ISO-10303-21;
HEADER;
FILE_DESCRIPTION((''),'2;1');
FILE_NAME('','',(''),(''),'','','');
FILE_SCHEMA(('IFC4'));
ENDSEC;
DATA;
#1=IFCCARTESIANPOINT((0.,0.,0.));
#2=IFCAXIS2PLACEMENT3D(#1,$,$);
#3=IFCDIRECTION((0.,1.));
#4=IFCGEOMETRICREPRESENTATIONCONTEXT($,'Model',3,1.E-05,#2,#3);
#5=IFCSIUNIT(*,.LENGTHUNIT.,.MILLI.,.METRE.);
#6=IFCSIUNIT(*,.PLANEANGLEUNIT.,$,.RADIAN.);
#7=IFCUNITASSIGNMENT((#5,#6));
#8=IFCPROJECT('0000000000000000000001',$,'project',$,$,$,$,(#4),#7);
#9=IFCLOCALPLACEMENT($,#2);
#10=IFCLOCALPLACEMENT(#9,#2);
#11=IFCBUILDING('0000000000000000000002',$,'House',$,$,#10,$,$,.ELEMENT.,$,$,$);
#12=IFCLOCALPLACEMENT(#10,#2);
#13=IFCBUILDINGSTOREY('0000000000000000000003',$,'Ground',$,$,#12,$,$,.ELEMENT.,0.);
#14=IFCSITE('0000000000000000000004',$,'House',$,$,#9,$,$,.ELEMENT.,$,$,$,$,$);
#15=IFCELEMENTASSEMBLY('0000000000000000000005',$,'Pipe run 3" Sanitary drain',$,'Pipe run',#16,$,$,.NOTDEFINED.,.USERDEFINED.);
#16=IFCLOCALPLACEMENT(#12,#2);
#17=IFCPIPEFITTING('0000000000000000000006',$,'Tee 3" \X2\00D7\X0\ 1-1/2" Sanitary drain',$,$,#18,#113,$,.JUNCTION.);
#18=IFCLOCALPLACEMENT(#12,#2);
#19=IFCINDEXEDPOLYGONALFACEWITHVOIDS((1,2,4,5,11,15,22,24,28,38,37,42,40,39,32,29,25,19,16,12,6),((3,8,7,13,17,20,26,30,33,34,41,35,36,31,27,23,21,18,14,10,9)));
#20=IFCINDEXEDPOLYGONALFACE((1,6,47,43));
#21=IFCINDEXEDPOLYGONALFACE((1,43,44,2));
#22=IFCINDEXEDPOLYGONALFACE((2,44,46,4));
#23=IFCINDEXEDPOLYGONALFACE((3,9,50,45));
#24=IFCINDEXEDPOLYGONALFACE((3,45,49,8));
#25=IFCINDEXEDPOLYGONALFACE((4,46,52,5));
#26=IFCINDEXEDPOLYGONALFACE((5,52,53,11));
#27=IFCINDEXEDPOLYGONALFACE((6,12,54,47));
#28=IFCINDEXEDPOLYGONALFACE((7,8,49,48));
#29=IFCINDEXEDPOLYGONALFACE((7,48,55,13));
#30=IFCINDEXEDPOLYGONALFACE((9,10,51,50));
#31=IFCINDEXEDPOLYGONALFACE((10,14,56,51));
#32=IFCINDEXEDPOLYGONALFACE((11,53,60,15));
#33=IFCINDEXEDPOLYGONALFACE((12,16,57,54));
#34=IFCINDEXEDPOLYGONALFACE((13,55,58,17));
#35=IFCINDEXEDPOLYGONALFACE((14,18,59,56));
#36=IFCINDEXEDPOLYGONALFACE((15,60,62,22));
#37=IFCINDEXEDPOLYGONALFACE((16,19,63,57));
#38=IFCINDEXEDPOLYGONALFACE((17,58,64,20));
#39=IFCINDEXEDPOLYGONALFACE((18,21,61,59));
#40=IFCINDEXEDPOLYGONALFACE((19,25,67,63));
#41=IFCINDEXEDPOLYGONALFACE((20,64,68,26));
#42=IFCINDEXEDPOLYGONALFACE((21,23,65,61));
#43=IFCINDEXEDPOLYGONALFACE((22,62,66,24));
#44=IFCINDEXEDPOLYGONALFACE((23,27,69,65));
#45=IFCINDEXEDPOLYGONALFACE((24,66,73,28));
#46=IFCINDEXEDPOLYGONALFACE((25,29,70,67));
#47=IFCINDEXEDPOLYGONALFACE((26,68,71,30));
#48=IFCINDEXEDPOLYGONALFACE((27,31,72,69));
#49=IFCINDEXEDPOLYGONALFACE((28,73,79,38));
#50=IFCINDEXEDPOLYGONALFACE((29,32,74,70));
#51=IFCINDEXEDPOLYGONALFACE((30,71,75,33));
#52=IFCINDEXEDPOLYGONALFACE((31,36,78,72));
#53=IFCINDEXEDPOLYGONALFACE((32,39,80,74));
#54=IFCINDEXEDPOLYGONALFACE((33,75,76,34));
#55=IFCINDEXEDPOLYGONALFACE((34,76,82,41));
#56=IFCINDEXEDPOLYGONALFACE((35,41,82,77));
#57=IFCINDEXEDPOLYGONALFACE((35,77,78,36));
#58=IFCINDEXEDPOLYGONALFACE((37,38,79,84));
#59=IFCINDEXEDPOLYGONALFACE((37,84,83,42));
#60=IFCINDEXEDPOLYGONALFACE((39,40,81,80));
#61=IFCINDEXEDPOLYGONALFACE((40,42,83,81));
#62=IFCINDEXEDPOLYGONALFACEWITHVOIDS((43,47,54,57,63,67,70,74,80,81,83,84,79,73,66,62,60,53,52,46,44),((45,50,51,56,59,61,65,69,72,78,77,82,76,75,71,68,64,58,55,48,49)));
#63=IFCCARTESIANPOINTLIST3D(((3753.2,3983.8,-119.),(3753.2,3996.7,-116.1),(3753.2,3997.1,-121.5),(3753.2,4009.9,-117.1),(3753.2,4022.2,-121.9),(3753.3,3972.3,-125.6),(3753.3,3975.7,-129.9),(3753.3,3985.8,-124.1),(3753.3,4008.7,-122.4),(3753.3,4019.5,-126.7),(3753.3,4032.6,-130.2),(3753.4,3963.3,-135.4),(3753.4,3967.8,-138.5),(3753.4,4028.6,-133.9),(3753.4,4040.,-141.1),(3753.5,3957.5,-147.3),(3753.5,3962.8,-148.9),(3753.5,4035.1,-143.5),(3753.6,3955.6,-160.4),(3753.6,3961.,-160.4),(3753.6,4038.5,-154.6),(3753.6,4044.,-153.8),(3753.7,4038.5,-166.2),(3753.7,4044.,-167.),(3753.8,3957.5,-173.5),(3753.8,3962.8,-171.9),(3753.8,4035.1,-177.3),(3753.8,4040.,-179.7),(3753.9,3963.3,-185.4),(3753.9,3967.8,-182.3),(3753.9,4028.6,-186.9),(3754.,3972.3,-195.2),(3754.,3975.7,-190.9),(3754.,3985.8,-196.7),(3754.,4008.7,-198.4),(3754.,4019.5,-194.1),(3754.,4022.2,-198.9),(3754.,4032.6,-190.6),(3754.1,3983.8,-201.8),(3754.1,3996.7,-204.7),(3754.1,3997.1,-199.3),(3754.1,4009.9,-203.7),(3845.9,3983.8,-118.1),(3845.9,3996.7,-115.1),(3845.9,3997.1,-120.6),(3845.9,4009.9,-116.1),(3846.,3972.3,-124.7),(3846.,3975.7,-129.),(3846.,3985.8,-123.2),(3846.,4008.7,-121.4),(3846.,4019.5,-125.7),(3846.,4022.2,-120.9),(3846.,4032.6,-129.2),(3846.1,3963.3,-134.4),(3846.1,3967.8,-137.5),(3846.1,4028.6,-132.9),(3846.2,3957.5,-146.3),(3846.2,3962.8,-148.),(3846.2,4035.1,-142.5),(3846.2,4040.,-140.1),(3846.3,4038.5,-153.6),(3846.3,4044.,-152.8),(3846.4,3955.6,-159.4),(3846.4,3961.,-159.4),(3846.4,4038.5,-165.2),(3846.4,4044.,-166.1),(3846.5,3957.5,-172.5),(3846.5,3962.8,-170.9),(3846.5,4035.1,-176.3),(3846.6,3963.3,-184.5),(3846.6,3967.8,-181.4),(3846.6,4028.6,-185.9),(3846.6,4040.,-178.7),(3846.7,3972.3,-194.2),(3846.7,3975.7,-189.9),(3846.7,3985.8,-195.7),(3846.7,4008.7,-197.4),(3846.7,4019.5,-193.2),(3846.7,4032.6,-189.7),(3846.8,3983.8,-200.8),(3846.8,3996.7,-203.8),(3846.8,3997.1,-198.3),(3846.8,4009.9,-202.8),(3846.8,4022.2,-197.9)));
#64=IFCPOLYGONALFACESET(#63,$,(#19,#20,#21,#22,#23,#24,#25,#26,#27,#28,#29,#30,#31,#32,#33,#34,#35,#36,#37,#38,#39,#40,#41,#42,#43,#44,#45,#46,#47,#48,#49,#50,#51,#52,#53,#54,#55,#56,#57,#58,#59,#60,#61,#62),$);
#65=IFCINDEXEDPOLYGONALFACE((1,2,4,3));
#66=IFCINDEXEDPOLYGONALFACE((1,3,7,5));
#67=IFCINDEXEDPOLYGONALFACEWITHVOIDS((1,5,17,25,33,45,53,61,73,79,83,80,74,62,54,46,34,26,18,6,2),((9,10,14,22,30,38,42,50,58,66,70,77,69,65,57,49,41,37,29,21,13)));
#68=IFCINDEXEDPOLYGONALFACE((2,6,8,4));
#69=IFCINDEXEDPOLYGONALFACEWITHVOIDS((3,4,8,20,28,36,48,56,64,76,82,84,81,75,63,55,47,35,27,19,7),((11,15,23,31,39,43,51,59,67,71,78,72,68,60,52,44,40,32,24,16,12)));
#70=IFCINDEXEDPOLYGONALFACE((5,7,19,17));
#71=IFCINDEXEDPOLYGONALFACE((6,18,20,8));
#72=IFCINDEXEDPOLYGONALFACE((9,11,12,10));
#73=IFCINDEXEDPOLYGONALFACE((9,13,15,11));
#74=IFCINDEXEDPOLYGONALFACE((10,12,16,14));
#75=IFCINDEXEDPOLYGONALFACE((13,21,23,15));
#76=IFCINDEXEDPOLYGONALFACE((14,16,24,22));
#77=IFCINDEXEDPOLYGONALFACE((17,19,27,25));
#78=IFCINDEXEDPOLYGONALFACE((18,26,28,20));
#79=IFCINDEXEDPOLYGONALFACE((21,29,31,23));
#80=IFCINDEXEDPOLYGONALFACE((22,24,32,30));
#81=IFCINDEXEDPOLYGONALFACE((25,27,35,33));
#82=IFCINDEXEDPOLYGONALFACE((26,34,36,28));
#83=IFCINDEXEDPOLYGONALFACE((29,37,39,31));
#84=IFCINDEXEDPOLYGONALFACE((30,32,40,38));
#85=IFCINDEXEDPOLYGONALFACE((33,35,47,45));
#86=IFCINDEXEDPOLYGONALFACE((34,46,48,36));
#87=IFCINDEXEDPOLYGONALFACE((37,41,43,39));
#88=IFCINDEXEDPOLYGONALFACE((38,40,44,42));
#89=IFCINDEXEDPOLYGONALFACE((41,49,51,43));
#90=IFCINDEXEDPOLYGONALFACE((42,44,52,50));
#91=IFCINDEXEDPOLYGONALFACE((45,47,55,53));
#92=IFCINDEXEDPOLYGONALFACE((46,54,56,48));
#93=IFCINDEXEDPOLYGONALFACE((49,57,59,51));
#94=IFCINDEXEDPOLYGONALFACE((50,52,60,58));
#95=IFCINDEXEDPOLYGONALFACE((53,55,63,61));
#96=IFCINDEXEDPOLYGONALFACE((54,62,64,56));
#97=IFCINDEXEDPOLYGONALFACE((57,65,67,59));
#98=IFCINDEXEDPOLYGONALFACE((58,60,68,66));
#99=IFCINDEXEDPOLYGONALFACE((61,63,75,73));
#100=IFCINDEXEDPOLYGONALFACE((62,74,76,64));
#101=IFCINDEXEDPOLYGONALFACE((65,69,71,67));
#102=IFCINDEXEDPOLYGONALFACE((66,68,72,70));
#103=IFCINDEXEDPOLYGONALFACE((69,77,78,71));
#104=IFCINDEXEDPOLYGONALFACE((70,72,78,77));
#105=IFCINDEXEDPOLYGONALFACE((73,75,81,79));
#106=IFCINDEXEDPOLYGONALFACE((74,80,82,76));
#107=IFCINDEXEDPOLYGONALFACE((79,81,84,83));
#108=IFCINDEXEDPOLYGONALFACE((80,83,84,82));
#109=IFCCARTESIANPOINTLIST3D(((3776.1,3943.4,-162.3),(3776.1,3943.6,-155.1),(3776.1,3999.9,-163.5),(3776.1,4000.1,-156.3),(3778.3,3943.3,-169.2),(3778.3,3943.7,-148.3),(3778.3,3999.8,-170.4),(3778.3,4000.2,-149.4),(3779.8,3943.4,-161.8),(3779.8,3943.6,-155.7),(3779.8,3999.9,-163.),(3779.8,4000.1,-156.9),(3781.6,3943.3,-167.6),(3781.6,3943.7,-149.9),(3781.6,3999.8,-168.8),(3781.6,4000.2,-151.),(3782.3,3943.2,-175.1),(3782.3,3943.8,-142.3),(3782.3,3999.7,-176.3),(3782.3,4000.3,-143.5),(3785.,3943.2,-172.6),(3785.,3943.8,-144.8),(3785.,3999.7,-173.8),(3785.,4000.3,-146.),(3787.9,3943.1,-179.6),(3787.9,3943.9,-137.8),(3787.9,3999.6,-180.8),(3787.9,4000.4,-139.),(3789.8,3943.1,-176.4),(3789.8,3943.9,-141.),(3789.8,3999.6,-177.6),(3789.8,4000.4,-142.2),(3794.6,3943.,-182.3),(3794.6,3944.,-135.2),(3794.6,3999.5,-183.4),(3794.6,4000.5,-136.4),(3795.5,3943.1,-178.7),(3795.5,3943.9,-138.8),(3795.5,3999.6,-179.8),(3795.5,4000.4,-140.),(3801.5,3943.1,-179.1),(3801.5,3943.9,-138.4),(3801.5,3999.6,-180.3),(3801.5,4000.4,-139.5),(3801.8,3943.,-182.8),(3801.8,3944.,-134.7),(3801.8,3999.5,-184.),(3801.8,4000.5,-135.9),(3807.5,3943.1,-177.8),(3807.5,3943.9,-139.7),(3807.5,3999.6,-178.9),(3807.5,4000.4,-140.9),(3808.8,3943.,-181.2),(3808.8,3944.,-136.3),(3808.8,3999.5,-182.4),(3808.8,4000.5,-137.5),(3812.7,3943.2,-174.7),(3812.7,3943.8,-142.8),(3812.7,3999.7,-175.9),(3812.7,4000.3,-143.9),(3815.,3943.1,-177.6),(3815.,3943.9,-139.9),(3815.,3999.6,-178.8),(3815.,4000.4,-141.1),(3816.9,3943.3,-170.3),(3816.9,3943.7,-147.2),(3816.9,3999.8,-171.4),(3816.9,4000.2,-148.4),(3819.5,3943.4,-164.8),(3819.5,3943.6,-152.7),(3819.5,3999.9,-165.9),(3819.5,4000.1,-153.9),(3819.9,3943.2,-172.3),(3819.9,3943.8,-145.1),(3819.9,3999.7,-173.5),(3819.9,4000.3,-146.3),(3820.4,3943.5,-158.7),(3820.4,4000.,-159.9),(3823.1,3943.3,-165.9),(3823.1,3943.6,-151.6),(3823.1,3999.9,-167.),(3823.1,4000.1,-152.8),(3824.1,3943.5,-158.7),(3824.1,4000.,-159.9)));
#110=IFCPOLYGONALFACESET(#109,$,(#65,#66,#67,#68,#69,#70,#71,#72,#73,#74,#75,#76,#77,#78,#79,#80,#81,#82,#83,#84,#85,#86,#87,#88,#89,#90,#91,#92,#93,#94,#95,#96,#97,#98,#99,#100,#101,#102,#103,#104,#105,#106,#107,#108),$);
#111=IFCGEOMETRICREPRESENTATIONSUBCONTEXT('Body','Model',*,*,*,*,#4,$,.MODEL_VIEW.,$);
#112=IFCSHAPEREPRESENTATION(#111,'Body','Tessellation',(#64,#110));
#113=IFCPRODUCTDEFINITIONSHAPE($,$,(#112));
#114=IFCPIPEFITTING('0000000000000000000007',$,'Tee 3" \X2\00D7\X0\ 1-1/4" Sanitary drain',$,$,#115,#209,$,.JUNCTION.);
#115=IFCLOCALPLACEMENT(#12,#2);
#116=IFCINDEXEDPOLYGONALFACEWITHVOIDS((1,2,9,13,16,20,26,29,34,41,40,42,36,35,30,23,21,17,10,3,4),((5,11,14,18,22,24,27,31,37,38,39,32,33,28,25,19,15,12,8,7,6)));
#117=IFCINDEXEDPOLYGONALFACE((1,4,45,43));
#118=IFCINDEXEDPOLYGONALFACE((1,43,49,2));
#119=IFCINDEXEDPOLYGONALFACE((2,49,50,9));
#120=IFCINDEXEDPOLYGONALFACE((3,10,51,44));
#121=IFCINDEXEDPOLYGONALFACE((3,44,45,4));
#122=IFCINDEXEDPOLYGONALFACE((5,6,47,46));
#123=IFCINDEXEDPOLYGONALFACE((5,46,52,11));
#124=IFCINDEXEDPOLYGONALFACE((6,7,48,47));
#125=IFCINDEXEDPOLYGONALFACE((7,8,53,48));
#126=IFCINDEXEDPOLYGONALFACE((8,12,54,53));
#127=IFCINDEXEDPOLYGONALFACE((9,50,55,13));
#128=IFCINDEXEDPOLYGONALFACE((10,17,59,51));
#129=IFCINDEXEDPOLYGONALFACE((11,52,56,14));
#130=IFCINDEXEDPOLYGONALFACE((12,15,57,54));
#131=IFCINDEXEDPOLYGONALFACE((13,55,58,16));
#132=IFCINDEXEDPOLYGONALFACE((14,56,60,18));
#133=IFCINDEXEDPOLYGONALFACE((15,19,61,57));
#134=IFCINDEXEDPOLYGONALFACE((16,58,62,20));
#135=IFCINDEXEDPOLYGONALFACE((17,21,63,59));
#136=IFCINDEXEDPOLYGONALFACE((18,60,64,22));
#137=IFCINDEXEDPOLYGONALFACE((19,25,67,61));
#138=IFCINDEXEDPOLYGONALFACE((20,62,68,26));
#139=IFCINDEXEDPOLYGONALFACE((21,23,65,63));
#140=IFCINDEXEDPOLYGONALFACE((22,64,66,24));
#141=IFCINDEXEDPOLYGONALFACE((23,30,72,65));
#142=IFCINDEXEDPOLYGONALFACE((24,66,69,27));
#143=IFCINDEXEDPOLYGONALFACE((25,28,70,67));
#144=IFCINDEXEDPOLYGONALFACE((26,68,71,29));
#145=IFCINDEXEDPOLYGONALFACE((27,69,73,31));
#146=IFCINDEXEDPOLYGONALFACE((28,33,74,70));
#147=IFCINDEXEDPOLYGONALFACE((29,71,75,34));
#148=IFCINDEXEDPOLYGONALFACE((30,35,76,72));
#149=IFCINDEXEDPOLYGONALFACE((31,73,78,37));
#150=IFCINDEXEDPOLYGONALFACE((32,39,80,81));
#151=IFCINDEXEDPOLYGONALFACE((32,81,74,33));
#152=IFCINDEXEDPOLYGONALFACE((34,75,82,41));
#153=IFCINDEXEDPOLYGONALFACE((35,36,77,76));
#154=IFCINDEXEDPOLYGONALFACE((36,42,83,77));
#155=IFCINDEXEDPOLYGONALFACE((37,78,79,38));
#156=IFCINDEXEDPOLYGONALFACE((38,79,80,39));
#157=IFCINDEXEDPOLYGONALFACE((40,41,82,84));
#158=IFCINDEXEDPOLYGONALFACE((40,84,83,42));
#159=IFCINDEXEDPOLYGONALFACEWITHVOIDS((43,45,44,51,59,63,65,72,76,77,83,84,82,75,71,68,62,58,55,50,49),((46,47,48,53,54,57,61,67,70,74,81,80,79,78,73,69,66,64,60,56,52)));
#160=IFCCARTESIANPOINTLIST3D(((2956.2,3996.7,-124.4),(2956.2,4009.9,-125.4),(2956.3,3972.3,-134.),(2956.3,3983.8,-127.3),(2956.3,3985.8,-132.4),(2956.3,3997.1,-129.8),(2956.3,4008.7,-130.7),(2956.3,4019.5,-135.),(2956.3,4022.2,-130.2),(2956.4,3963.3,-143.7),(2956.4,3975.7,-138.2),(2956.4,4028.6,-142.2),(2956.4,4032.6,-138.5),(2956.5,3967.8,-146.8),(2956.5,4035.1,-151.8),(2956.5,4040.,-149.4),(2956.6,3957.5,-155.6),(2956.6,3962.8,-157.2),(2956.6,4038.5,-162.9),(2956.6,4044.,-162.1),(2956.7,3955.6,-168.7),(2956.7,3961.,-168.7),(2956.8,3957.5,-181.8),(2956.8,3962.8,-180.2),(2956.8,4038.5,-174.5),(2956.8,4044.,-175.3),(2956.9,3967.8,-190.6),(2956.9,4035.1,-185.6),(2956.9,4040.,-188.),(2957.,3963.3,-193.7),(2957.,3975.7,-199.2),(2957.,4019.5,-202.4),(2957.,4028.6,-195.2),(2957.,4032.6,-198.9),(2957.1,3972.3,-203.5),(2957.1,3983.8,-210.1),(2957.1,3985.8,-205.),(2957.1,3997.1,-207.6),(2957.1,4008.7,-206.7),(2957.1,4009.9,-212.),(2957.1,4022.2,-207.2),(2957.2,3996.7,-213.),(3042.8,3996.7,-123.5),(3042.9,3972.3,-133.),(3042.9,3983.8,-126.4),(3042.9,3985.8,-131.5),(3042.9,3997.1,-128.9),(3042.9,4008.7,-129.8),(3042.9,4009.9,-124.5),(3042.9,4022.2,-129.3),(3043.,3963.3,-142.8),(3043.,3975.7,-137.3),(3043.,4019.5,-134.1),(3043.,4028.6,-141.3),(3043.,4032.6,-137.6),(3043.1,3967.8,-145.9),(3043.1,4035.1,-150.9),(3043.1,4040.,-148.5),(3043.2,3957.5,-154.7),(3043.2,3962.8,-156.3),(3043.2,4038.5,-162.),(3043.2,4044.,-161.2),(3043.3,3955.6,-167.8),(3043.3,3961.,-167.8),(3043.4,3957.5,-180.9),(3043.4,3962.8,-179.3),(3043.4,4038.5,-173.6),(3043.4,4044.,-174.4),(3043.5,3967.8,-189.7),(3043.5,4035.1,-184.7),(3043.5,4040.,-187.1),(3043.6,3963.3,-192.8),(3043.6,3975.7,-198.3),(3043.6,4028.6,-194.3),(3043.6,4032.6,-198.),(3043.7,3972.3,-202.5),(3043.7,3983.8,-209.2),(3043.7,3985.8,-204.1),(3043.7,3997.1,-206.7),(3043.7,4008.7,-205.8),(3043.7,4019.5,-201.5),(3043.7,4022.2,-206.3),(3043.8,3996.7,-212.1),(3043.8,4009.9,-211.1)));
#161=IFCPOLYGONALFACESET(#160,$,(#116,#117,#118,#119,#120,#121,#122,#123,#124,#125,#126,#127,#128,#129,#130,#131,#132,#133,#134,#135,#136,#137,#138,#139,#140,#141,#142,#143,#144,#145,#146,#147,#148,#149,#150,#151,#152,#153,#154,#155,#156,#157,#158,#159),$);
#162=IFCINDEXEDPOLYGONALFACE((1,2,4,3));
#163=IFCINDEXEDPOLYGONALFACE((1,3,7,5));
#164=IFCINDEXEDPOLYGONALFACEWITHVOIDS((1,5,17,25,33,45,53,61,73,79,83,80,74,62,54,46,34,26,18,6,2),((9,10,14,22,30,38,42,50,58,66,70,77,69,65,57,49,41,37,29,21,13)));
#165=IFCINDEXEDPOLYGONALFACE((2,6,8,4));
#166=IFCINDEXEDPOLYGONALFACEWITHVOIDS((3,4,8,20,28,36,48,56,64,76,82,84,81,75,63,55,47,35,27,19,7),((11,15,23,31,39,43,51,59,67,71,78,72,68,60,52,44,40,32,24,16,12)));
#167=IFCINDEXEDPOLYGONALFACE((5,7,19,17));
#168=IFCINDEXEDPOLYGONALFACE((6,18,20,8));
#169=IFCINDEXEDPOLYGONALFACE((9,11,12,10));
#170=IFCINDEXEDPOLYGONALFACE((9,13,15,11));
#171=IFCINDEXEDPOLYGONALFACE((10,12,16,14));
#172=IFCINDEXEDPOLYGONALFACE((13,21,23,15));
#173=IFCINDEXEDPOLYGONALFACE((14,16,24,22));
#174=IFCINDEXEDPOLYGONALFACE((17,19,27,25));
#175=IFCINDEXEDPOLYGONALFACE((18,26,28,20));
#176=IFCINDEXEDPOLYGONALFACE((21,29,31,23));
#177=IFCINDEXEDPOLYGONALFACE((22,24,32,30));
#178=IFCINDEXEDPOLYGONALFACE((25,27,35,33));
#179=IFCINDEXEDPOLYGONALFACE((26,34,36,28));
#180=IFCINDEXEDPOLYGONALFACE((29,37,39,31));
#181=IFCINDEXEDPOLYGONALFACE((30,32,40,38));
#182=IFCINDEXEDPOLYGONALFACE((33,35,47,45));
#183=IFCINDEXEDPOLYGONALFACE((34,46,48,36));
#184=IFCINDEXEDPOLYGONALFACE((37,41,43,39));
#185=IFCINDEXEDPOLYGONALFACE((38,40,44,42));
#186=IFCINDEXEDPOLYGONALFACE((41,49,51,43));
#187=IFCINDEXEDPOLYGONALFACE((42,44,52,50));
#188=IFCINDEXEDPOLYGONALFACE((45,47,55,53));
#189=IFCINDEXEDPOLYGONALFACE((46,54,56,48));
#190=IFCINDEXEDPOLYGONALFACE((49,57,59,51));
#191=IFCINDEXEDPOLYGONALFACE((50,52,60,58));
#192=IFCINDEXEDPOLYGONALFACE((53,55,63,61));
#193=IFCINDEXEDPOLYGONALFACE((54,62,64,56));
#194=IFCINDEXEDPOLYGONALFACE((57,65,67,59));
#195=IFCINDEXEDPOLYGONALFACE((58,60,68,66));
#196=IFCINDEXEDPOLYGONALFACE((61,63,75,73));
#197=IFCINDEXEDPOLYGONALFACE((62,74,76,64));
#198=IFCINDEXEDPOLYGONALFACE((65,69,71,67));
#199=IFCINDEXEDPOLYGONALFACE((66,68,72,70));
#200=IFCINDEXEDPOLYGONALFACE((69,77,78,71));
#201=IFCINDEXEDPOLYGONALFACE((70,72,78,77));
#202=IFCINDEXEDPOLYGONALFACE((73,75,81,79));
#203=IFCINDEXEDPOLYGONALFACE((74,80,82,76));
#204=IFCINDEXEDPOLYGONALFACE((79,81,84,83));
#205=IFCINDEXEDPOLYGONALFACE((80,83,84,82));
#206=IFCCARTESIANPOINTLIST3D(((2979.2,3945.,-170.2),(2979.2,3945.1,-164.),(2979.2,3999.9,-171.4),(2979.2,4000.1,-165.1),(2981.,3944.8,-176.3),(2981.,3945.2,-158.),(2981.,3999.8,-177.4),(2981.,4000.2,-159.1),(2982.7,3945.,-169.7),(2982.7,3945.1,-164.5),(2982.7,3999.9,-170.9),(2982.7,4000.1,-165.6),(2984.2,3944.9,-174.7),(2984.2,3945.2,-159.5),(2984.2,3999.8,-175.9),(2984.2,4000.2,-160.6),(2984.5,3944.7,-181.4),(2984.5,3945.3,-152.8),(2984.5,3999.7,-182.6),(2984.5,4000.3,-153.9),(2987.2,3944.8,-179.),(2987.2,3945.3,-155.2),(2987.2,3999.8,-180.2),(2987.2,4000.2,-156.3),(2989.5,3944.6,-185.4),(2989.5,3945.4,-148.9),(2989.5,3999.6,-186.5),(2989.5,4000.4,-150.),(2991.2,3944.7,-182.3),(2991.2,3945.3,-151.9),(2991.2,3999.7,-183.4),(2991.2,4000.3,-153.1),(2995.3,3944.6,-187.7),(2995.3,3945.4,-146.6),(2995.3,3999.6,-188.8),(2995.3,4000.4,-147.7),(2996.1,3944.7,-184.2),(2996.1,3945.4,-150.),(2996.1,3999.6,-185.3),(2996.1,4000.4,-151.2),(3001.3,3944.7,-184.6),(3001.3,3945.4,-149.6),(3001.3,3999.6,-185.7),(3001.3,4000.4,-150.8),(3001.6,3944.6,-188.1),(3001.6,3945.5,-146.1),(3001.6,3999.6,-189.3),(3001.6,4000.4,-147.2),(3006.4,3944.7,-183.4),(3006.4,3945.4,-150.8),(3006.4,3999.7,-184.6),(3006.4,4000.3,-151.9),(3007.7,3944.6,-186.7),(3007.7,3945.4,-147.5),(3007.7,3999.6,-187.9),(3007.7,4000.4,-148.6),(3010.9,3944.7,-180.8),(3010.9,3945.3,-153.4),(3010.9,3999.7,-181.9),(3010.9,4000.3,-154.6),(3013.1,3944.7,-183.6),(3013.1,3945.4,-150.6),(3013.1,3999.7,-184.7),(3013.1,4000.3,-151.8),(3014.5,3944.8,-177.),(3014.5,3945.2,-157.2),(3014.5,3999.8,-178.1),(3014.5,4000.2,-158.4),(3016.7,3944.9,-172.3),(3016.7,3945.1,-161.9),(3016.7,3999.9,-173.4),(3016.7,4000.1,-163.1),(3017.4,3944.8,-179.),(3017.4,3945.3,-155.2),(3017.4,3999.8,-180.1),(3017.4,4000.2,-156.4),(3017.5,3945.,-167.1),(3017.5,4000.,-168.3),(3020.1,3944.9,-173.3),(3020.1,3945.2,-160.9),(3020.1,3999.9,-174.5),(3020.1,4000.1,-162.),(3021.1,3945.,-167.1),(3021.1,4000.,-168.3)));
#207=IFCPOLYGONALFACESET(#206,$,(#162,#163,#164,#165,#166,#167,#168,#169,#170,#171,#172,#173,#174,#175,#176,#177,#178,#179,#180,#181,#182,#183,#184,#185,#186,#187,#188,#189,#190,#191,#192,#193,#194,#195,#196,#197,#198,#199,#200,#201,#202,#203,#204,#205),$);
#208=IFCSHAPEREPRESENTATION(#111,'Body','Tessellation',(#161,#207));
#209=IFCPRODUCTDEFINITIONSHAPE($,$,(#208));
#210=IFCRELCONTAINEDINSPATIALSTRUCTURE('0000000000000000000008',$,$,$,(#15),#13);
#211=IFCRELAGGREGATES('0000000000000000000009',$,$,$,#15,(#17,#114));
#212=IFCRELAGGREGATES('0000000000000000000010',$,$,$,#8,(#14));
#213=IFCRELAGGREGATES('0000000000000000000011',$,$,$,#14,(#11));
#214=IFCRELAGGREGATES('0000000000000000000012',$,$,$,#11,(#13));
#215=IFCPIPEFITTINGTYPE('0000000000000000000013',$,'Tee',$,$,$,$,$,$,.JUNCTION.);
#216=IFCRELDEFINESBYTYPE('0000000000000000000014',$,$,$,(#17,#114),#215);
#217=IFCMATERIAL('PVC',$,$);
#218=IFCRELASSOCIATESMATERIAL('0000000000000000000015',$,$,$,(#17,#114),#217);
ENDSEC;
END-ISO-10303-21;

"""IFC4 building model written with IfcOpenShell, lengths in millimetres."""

from ifc_helpers import new_model, si_unit, direction, frame, origin, origin_with_axes, origin_2d, place, context, subcontext, project, spatial, hollow_circle, extrude, material, type_object, element, aggregate, save


model = new_model("IFC4")

# Units and contexts
model_context = context("Model", 3, precision=1e-05, world=origin(), true_north=direction((0.0, 1.0)))
body_context = subcontext(model_context, "Body", "Model", "MODEL_VIEW")
ifc_project = project(units=[si_unit("LENGTHUNIT", "METRE", prefix="MILLI"), si_unit("PLANEANGLEUNIT", "RADIAN")], contexts=[model_context])

# Site, building, storey
site_placement = place(None, origin())
site = spatial("IfcSite", under=ifc_project, at=site_placement, Name="House", CompositionType="ELEMENT")
building_placement = place(site_placement, origin())
building = spatial("IfcBuilding", under=site, at=building_placement, Name="House", CompositionType="ELEMENT")
storey_placement = place(building_placement, origin())
storey = spatial("IfcBuildingStorey", under=building, at=storey_placement, Name="Ground", CompositionType="ELEMENT", Elevation=0.0)

# Element assembly
ifc_material = material(Name="PVC")
assembly_1_placement = place(storey_placement, origin_with_axes())
assembly_1 = element("IfcElementAssembly", 1, at=assembly_1_placement, inside=storey, Name="Pipe run 3\" Sanitary drain", ObjectType="Pipe run", AssemblyPlace="NOTDEFINED", PredefinedType="USERDEFINED")

# Pipe fittings
pipe_fitting_type_1 = type_object("IfcPipeFittingType", Name="Tee", PredefinedType="JUNCTION")
pipe_fitting_1_placement = place(storey_placement, origin_with_axes())
pipe_fitting_1 = element("IfcPipeFitting", 2, at=pipe_fitting_1_placement, type_object=pipe_fitting_type_1, material=ifc_material, Name="Tee 3\" × 1-1/2\" Sanitary drain", PredefinedType="JUNCTION", context=body_context, shape_type="SweptSolid", body=[
    extrude(hollow_circle(Radius=44.5, WallThickness=5.5, at=origin_2d()), frame((3846.4, 4000.0, -159.4), z_axis=(-0.999946, 0.0, -0.010416), x_axis=(0.0, -1.0, 0.0)), (0.0, 0.0, 1.0), 92.7),
    extrude(hollow_circle(Radius=24.1, WallThickness=3.7, at=origin_2d()), frame((3800.0, 4000.0, -159.9), z_axis=(0.0, -0.999783, 0.020829), x_axis=(1.0, 0.0, 0.0)), (0.0, 0.0, 1.0), 56.5),
])
pipe_fitting_2_placement = place(storey_placement, origin_with_axes())
pipe_fitting_2 = element("IfcPipeFitting", 3, at=pipe_fitting_2_placement, type_object=pipe_fitting_type_1, material=ifc_material, Name="Tee 3\" × 1-1/4\" Sanitary drain", PredefinedType="JUNCTION", context=body_context, shape_type="SweptSolid", body=[
    extrude(hollow_circle(Radius=44.5, WallThickness=5.5, at=origin_2d()), frame((3043.3, 4000.0, -167.8), z_axis=(-0.999946, 0.0, -0.010416), x_axis=(0.0, -1.0, 0.0)), (0.0, 0.0, 1.0), 86.6),
    extrude(hollow_circle(Radius=21.1, WallThickness=3.6, at=origin_2d()), frame((3000.0, 4000.0, -168.3), z_axis=(0.0, -0.999783, 0.020829), x_axis=(1.0, 0.0, 0.0)), (0.0, 0.0, 1.0), 55.0),
])
aggregate(assembly_1, [pipe_fitting_1, pipe_fitting_2])

save(model, "model.ifc")
